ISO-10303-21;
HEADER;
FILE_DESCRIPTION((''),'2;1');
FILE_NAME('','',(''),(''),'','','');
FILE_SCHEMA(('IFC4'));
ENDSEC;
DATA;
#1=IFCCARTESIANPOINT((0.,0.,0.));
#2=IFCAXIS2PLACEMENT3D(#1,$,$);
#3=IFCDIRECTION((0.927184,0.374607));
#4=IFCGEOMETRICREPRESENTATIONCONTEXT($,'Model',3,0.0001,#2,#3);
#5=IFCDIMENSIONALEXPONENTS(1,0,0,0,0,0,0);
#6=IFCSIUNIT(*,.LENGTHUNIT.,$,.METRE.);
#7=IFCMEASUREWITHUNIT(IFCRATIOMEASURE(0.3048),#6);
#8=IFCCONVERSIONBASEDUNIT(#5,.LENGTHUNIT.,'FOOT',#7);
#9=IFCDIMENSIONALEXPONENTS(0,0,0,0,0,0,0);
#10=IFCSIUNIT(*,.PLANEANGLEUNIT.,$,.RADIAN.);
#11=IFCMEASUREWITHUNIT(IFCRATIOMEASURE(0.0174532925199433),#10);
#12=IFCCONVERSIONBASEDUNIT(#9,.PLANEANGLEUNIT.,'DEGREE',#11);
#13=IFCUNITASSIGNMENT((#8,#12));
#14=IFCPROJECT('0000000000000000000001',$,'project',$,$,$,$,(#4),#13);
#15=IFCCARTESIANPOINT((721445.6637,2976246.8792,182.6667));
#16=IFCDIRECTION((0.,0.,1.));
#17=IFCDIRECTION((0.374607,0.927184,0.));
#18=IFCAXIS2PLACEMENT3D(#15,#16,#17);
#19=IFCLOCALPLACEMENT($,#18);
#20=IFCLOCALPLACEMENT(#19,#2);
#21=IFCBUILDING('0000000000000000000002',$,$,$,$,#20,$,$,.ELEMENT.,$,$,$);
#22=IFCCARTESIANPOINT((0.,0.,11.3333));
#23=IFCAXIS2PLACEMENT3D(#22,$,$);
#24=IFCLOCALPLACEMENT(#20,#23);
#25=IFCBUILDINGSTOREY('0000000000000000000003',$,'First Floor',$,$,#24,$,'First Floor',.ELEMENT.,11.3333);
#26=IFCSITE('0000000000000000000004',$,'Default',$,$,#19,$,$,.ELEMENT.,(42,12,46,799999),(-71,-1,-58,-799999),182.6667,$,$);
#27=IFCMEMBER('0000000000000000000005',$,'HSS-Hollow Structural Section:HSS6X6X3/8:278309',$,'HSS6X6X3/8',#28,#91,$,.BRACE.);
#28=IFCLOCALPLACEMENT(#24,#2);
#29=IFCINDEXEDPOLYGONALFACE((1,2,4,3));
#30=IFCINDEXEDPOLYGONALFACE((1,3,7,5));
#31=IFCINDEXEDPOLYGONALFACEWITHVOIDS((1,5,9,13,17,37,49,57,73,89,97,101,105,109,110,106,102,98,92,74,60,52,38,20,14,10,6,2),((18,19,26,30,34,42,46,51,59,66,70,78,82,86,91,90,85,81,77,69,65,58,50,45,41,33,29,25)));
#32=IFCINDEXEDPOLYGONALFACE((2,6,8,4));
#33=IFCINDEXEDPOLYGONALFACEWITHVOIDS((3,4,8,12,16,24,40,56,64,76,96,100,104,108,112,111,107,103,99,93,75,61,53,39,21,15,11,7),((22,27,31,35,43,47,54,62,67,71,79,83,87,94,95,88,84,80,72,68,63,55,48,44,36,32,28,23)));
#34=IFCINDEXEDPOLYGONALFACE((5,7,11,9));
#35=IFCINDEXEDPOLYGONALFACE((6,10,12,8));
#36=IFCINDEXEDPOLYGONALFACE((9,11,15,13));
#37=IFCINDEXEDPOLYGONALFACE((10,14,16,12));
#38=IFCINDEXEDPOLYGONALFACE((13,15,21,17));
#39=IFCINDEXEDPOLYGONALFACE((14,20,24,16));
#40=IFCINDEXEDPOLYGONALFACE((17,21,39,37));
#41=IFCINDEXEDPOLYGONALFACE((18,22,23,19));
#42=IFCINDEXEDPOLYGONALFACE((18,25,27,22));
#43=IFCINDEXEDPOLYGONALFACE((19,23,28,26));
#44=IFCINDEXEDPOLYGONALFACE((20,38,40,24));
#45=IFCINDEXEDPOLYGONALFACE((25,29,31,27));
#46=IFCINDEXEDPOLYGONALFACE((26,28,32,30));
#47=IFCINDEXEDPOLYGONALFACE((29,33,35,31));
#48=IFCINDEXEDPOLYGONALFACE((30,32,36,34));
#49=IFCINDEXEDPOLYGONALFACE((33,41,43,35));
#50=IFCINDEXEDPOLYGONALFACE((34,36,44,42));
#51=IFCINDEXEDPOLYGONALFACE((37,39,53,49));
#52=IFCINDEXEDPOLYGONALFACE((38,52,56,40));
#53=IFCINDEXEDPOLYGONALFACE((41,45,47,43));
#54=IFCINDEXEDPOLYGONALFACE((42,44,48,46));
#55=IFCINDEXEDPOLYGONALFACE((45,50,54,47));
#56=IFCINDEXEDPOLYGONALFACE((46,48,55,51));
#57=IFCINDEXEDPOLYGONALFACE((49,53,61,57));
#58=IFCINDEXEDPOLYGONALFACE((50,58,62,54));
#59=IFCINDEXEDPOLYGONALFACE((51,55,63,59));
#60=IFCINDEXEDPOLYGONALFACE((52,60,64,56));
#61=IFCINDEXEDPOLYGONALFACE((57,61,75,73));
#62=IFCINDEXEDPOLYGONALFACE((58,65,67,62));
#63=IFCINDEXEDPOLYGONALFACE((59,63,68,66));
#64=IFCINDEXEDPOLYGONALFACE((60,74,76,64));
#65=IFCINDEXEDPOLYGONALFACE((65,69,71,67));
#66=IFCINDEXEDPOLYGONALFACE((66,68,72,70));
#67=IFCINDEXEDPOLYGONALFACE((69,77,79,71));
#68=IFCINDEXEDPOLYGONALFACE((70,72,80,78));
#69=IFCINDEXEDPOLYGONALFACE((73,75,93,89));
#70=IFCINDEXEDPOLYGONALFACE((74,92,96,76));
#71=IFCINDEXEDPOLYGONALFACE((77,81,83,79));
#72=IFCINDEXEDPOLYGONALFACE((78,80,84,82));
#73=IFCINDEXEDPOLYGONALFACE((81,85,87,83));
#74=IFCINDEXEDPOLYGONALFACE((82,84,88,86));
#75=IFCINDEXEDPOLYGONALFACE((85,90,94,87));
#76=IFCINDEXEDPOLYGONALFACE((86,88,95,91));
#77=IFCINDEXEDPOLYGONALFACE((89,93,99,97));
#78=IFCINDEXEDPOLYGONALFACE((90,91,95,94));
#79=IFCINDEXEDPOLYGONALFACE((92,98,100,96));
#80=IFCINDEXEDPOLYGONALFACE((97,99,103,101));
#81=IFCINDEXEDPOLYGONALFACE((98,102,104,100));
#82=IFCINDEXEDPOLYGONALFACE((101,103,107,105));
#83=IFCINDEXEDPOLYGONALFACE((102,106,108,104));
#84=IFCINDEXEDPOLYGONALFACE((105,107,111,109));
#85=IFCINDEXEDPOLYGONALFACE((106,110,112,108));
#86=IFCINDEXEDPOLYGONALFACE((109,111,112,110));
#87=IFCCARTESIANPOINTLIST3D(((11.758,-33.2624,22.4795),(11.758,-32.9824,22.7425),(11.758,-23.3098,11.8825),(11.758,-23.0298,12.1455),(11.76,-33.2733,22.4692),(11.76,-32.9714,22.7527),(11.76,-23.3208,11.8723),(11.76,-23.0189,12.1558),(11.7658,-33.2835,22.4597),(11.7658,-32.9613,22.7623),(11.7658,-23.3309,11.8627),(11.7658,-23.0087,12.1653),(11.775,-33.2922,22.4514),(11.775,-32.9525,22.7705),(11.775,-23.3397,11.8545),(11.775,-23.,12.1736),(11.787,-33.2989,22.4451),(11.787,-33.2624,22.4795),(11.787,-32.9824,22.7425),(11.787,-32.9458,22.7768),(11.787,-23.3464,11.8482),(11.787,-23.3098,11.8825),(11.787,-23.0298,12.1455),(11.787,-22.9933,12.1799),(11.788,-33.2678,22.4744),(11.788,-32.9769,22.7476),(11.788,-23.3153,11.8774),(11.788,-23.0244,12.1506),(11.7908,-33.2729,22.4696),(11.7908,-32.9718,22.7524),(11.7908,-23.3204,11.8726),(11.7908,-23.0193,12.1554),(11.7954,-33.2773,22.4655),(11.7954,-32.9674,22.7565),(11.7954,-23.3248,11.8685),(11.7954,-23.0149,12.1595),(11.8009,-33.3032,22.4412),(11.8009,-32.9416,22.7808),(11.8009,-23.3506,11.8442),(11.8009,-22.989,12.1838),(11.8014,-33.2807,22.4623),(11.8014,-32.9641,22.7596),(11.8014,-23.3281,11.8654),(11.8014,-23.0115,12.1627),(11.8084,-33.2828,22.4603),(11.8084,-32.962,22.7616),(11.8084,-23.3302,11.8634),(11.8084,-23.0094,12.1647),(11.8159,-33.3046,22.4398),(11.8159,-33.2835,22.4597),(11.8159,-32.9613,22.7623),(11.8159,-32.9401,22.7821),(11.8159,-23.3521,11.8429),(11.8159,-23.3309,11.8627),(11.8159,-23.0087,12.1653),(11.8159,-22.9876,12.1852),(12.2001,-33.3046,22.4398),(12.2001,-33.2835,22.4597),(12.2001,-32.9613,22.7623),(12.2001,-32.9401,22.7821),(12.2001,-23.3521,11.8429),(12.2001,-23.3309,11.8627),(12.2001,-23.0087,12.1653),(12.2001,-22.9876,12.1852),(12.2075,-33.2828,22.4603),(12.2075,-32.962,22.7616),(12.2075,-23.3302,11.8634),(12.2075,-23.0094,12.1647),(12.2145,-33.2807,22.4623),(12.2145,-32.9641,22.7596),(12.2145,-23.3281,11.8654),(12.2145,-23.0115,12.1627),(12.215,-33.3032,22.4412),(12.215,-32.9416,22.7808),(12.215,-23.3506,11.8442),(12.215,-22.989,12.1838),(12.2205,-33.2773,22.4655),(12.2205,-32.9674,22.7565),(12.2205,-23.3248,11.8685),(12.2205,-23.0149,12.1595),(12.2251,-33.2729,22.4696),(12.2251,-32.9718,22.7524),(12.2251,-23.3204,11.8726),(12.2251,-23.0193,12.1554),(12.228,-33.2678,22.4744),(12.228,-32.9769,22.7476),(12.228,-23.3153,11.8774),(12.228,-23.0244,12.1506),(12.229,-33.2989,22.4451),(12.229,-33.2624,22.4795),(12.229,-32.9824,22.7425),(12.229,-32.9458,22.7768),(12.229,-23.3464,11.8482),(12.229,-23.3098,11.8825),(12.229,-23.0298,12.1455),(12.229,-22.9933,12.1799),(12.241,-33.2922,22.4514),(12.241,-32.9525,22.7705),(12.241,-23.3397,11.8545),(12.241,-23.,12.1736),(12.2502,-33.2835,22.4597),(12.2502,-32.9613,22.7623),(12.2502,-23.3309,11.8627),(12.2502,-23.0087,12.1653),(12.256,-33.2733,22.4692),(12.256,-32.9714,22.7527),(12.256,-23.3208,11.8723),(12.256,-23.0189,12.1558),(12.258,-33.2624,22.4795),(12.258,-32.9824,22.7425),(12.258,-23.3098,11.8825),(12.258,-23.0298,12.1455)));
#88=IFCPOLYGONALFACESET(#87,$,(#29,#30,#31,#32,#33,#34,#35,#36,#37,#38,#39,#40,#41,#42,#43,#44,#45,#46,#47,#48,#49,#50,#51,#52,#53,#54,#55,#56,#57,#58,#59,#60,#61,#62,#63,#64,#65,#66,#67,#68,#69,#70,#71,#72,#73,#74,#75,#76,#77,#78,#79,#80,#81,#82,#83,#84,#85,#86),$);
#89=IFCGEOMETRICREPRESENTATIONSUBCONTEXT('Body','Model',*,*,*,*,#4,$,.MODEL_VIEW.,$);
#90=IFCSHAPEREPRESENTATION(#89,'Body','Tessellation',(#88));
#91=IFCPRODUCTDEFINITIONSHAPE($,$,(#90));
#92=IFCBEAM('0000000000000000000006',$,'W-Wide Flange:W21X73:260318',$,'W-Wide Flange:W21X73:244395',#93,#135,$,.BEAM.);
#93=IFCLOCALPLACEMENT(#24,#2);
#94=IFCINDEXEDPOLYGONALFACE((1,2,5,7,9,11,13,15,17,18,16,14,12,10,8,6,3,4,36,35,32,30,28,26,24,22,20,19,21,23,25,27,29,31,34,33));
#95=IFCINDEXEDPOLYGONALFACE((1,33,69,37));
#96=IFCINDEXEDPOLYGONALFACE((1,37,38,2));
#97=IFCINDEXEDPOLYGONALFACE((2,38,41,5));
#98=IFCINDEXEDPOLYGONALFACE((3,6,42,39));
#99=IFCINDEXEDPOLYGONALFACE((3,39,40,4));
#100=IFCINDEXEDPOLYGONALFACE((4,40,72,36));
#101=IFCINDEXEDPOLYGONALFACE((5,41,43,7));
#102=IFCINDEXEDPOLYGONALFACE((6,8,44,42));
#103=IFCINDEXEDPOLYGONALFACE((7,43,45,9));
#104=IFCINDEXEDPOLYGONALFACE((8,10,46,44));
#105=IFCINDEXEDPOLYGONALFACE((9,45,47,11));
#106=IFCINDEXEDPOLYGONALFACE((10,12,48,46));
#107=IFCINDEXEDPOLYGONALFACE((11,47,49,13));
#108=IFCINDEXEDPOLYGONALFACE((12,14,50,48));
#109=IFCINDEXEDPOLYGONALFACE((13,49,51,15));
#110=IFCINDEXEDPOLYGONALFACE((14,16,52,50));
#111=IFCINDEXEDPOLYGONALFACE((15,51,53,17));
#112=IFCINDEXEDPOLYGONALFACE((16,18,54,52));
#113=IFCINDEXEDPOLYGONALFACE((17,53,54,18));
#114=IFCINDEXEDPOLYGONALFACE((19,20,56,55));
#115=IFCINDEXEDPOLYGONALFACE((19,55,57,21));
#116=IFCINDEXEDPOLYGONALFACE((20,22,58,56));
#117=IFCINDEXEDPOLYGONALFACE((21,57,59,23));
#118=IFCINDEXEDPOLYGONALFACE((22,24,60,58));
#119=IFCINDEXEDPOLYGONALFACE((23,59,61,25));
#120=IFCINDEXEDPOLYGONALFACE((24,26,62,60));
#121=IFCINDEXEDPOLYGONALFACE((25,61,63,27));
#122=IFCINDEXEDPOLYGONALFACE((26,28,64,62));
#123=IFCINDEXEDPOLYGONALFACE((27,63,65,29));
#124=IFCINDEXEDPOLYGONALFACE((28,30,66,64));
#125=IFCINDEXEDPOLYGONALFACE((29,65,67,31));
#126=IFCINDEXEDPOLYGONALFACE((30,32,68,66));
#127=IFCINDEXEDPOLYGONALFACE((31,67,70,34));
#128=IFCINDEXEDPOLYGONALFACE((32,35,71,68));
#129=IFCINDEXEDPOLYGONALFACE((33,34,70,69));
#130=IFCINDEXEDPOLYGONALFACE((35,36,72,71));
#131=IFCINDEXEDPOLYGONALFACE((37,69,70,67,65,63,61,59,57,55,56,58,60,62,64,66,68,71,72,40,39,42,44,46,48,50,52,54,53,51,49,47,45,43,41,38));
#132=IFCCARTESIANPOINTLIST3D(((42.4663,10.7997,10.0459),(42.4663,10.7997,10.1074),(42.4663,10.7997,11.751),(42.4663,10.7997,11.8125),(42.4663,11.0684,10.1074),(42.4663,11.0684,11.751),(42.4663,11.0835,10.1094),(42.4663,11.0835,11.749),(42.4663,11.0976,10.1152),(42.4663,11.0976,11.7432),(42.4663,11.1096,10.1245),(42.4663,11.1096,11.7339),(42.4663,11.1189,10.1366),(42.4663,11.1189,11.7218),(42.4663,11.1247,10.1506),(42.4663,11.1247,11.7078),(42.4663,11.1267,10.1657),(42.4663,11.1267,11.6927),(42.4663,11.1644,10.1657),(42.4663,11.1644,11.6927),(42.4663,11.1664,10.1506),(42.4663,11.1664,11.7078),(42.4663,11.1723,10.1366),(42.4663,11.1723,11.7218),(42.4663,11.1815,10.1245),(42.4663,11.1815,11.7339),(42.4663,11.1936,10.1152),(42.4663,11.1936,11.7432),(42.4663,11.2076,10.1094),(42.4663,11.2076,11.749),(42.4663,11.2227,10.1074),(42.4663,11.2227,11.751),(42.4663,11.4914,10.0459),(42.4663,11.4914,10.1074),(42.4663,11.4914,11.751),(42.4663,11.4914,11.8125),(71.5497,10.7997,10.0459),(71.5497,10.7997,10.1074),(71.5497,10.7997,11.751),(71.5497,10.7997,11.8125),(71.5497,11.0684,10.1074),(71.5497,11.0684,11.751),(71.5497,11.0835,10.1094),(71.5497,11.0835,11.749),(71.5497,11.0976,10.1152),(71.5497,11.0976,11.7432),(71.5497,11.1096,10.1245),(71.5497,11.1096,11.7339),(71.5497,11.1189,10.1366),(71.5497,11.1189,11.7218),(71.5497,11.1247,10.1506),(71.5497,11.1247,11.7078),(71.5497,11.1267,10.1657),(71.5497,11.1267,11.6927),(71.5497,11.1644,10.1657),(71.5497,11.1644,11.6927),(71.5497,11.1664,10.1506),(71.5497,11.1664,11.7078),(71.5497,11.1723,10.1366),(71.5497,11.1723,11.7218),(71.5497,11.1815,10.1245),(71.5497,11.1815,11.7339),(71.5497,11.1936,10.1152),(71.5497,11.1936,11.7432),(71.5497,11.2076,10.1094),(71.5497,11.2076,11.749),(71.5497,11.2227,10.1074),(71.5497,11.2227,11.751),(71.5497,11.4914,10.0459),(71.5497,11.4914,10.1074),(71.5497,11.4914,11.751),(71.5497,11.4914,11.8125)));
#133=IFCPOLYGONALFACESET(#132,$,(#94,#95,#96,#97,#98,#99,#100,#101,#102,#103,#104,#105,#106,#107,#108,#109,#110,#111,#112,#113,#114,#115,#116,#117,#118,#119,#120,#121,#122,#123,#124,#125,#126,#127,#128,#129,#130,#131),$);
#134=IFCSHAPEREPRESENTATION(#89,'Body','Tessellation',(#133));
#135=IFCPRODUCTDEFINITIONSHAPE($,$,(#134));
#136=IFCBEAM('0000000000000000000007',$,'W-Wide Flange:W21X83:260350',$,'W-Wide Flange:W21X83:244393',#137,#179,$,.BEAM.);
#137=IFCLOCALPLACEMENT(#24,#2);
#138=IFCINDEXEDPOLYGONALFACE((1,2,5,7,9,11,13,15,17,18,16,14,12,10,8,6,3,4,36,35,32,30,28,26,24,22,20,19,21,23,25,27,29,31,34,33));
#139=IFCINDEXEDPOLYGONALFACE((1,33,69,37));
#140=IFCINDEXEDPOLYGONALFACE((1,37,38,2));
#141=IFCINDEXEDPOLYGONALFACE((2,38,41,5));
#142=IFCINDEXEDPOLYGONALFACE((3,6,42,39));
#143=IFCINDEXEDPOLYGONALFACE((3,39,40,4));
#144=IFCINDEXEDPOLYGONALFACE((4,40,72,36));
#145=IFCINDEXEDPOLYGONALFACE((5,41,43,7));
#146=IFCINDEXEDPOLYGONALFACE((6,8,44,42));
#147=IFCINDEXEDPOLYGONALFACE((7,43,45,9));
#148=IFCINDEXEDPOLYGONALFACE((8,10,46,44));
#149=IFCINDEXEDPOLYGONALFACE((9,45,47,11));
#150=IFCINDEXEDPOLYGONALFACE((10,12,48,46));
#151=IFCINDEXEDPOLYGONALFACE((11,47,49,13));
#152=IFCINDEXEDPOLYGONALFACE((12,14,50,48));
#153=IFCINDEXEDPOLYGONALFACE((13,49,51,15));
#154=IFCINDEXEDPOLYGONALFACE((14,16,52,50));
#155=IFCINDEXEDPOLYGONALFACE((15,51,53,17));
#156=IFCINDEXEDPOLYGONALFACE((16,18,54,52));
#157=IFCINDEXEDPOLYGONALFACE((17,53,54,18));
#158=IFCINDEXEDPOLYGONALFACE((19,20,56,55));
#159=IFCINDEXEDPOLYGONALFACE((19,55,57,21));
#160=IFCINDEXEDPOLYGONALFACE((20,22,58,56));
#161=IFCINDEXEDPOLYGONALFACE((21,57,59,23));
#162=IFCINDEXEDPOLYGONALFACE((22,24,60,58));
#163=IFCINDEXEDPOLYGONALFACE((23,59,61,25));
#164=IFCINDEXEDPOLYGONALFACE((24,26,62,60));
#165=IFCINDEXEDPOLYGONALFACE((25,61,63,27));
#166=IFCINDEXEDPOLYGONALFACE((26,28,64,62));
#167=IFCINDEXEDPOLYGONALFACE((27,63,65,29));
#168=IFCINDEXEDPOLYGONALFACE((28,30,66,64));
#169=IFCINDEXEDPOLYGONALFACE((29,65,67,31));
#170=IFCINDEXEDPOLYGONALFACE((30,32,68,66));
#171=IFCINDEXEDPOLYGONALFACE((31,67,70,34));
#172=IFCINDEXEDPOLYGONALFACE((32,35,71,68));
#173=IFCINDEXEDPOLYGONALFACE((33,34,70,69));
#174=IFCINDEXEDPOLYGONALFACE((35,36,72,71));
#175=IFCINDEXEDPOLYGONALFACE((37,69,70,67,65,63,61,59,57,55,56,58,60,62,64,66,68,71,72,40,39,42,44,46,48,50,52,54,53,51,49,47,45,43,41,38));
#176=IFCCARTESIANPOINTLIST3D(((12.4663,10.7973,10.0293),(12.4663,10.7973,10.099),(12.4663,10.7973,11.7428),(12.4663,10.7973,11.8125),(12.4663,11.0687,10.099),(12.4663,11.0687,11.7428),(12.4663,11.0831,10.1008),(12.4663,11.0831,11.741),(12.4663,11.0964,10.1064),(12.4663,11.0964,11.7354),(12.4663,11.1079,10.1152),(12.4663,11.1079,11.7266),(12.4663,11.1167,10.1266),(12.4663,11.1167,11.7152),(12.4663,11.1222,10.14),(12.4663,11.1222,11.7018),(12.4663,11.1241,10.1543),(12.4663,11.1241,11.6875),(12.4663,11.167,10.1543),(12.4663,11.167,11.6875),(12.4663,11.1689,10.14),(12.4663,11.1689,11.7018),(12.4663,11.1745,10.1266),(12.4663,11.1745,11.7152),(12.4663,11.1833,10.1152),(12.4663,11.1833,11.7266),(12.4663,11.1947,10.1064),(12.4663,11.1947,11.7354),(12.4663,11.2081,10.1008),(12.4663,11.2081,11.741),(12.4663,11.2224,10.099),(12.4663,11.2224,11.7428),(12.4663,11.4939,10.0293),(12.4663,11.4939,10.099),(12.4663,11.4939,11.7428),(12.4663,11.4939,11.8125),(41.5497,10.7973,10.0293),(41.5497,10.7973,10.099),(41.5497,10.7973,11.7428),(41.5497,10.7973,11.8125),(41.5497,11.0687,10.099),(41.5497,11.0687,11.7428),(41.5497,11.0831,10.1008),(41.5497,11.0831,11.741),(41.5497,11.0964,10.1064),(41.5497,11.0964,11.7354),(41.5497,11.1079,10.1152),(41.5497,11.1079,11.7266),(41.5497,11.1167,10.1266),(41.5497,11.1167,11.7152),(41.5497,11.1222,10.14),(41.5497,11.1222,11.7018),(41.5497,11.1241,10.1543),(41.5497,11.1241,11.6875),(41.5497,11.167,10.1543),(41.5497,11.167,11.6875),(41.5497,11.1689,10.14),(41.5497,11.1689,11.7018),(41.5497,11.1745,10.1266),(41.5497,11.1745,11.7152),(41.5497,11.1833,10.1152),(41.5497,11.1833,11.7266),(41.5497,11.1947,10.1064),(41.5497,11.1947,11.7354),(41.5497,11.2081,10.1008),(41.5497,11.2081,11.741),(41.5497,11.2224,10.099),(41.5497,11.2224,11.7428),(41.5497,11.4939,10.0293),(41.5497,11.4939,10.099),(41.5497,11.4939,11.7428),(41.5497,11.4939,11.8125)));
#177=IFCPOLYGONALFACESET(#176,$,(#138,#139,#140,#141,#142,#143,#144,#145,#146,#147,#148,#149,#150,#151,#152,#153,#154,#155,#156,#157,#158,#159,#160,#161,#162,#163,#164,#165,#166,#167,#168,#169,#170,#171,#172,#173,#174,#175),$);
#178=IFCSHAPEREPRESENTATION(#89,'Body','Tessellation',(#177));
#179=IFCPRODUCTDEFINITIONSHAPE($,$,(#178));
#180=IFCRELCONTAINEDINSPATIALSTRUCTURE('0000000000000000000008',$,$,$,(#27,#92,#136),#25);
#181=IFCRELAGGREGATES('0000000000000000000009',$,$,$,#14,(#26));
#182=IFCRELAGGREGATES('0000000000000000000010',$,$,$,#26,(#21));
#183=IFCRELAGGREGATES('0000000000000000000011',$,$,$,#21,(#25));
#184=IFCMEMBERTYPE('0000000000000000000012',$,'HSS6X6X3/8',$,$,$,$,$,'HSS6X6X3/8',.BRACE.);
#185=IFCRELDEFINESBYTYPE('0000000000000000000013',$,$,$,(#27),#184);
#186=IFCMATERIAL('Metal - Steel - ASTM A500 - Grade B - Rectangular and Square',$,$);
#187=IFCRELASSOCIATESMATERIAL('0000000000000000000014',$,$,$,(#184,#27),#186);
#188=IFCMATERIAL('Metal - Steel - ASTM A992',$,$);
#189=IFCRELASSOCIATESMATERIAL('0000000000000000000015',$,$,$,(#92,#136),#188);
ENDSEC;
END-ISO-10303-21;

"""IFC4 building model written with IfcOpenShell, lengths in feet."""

from ifc_helpers import new_model, entity, si_unit, converted_unit, direction, frame, frame_2d, origin, place, context, subcontext, project, spatial, polyline, circle_curve, parameter, trimmed, segment, composite_curve, i_section, outline, extrude, source, transform, mapped, material, type_object, type_shapes, element, save


model = new_model("IFC4")

# Units and contexts
model_context = context("Model", 3, precision=0.0001, world=origin(), true_north=direction((0.927184, 0.374607)))
body_context = subcontext(model_context, "Body", "Model", "MODEL_VIEW")
ifc_project = project(units=[converted_unit("LENGTHUNIT", "FOOT", entity("IfcRatioMeasure", 0.3048), si_unit("LENGTHUNIT", "METRE"), dimensions=[1, 0, 0, 0, 0, 0, 0]), converted_unit("PLANEANGLEUNIT", "DEGREE", entity("IfcRatioMeasure", 0.0174532925199433), si_unit("PLANEANGLEUNIT", "RADIAN"), dimensions=[0, 0, 0, 0, 0, 0, 0])], contexts=[model_context])

# Site, building, storey
site_placement = place(None, frame((721445.6637, 2976246.8792, 182.6667), z_axis=(0.0, 0.0, 1.0), x_axis=(0.374607, 0.927184, 0.0)))
site = spatial("IfcSite", under=ifc_project, at=site_placement, Name="Default", CompositionType="ELEMENT", RefLatitude=(42, 12, 46, 799999), RefLongitude=(-71, -1, -58, -799999), RefElevation=182.6667)
building_placement = place(site_placement, origin())
building = spatial("IfcBuilding", under=site, at=building_placement, CompositionType="ELEMENT")
storey_placement = place(building_placement, frame((0.0, 0.0, 11.3333)))
storey = spatial("IfcBuildingStorey", under=building, at=storey_placement, Name="First Floor", LongName="First Floor", CompositionType="ELEMENT", Elevation=11.3333)

# Member
ifc_material_1 = material(Name="Metal - Steel - ASTM A500 - Grade B - Rectangular and Square")
member_type = type_object("IfcMemberType", Name="HSS6X6X3/8", ElementType="HSS6X6X3/8", PredefinedType="BRACE", material=ifc_material_1)
shared_shape = source(origin(), body_context, "Body", "SweptSolid", [
    extrude(outline(composite_curve([segment(trimmed(circle_curve(frame_2d((-0.1921, -0.1921), x_axis=(1.0, 0.0)), 0.0579), [parameter(180.0)], [parameter(270.0)], True, "PARAMETER"), True, "CONTINUOUS"), segment(polyline([(-0.1921, -0.25), (0.1921, -0.25)]), True, "CONTINUOUS"), segment(trimmed(circle_curve(frame_2d((0.1921, -0.1921), x_axis=(1.0, 0.0)), 0.0579), [parameter(270.0)], [parameter(0.0)], True, "PARAMETER"), True, "CONTINUOUS"), segment(polyline([(0.25, -0.1921), (0.25, 0.1921)]), True, "CONTINUOUS"), segment(trimmed(circle_curve(frame_2d((0.1921, 0.1921), x_axis=(1.0, 0.0)), 0.0579), [parameter(360.0)], [parameter(90.0)], True, "PARAMETER"), True, "CONTINUOUS"), segment(polyline([(0.1921, 0.25), (-0.1921, 0.25)]), True, "CONTINUOUS"), segment(trimmed(circle_curve(frame_2d((-0.1921, 0.1921), x_axis=(1.0, 0.0)), 0.0579), [parameter(90.0)], [parameter(180.0)], True, "PARAMETER"), True, "CONTINUOUS"), segment(polyline([(-0.25, 0.1921), (-0.25, -0.1921)]), True, "CONTINUOUS")], self_intersect=False), holes=[composite_curve([segment(polyline([(0.1921, -0.221), (-0.1921, -0.221)]), True, "CONTINUOUS"), segment(trimmed(circle_curve(frame_2d((-0.1921, -0.1921), x_axis=(1.0, 0.0)), 0.029), [parameter(180.0)], [parameter(270.0)], True, "PARAMETER"), False, "CONTINUOUS"), segment(polyline([(-0.221, -0.1921), (-0.221, 0.1921)]), True, "CONTINUOUS"), segment(trimmed(circle_curve(frame_2d((-0.1921, 0.1921), x_axis=(1.0, 0.0)), 0.029), [parameter(90.0)], [parameter(180.0)], True, "PARAMETER"), False, "CONTINUOUS"), segment(polyline([(-0.1921, 0.221), (0.1921, 0.221)]), True, "CONTINUOUS"), segment(trimmed(circle_curve(frame_2d((0.1921, 0.1921), x_axis=(1.0, 0.0)), 0.029), [parameter(0.0)], [parameter(90.0)], True, "PARAMETER"), False, "CONTINUOUS"), segment(polyline([(0.221, 0.1921), (0.221, -0.1921)]), True, "CONTINUOUS"), segment(trimmed(circle_curve(frame_2d((0.1921, -0.1921), x_axis=(1.0, 0.0)), 0.029), [parameter(270.0)], [parameter(0.0)], True, "PARAMETER"), False, "CONTINUOUS")], self_intersect=False)]), frame((-7.2689, 0.0, 0.0), z_axis=(1.0, 0.0, 0.0), x_axis=(0.0, -1.0, 0.0)), (0.0, 0.0, 1.0), 14.5378),
])
type_shapes(member_type, [shared_shape])
member_placement = place(storey_placement, frame((12.008, -28.1461, 17.3125), z_axis=(0.0, 0.728923, 0.684596), x_axis=(0.0, -0.684596, 0.728923)))
element("IfcMember", 1, at=member_placement, inside=storey, type_object=member_type, material=ifc_material_1, Name="HSS-Hollow Structural Section:HSS6X6X3/8:278309", ObjectType="HSS6X6X3/8", PredefinedType="BRACE", context=body_context, shape_type="MappedRepresentation", body=[
    mapped(shared_shape, transform((0.0, 0.0, 0.0), scale=1.0)),
])

# Beams
ifc_material_2 = material(Name="Metal - Steel - ASTM A992")
beam_1_placement = place(storey_placement, frame((42.008, 11.1456, 11.8125)))
element("IfcBeam", 2, at=beam_1_placement, inside=storey, material=ifc_material_2, Name="W-Wide Flange:W21X73:260318", ObjectType="W-Wide Flange:W21X73:244395", PredefinedType="BEAM", context=body_context, shape_type="SweptSolid", body=[
    extrude(i_section(OverallWidth=0.6917, OverallDepth=1.7666, WebThickness=0.0378, FlangeThickness=0.0615, FilletRadius=0.0583, at=frame_2d((0.0, 0.0), x_axis=(0.0, 1.0))), frame((0.4583, 0.0, -0.8833), z_axis=(1.0, 0.0, 0.0), x_axis=(0.0, 0.0, -1.0)), (0.0, 0.0, 1.0), 29.0833),
])
beam_2_placement = place(storey_placement, frame((12.008, 11.1456, 11.8125)))
element("IfcBeam", 3, at=beam_2_placement, inside=storey, material=ifc_material_2, Name="W-Wide Flange:W21X83:260350", ObjectType="W-Wide Flange:W21X83:244393", PredefinedType="BEAM", context=body_context, shape_type="SweptSolid", body=[
    extrude(i_section(OverallWidth=0.6966, OverallDepth=1.7832, WebThickness=0.043, FlangeThickness=0.0697, FilletRadius=0.0553, at=frame_2d((0.0, 0.0), x_axis=(0.0, 1.0))), frame((0.4583, 0.0, -0.8916), z_axis=(1.0, 0.0, 0.0), x_axis=(0.0, 0.0, -1.0)), (0.0, 0.0, 1.0), 29.0833),
])

save(model, "model.ifc")
